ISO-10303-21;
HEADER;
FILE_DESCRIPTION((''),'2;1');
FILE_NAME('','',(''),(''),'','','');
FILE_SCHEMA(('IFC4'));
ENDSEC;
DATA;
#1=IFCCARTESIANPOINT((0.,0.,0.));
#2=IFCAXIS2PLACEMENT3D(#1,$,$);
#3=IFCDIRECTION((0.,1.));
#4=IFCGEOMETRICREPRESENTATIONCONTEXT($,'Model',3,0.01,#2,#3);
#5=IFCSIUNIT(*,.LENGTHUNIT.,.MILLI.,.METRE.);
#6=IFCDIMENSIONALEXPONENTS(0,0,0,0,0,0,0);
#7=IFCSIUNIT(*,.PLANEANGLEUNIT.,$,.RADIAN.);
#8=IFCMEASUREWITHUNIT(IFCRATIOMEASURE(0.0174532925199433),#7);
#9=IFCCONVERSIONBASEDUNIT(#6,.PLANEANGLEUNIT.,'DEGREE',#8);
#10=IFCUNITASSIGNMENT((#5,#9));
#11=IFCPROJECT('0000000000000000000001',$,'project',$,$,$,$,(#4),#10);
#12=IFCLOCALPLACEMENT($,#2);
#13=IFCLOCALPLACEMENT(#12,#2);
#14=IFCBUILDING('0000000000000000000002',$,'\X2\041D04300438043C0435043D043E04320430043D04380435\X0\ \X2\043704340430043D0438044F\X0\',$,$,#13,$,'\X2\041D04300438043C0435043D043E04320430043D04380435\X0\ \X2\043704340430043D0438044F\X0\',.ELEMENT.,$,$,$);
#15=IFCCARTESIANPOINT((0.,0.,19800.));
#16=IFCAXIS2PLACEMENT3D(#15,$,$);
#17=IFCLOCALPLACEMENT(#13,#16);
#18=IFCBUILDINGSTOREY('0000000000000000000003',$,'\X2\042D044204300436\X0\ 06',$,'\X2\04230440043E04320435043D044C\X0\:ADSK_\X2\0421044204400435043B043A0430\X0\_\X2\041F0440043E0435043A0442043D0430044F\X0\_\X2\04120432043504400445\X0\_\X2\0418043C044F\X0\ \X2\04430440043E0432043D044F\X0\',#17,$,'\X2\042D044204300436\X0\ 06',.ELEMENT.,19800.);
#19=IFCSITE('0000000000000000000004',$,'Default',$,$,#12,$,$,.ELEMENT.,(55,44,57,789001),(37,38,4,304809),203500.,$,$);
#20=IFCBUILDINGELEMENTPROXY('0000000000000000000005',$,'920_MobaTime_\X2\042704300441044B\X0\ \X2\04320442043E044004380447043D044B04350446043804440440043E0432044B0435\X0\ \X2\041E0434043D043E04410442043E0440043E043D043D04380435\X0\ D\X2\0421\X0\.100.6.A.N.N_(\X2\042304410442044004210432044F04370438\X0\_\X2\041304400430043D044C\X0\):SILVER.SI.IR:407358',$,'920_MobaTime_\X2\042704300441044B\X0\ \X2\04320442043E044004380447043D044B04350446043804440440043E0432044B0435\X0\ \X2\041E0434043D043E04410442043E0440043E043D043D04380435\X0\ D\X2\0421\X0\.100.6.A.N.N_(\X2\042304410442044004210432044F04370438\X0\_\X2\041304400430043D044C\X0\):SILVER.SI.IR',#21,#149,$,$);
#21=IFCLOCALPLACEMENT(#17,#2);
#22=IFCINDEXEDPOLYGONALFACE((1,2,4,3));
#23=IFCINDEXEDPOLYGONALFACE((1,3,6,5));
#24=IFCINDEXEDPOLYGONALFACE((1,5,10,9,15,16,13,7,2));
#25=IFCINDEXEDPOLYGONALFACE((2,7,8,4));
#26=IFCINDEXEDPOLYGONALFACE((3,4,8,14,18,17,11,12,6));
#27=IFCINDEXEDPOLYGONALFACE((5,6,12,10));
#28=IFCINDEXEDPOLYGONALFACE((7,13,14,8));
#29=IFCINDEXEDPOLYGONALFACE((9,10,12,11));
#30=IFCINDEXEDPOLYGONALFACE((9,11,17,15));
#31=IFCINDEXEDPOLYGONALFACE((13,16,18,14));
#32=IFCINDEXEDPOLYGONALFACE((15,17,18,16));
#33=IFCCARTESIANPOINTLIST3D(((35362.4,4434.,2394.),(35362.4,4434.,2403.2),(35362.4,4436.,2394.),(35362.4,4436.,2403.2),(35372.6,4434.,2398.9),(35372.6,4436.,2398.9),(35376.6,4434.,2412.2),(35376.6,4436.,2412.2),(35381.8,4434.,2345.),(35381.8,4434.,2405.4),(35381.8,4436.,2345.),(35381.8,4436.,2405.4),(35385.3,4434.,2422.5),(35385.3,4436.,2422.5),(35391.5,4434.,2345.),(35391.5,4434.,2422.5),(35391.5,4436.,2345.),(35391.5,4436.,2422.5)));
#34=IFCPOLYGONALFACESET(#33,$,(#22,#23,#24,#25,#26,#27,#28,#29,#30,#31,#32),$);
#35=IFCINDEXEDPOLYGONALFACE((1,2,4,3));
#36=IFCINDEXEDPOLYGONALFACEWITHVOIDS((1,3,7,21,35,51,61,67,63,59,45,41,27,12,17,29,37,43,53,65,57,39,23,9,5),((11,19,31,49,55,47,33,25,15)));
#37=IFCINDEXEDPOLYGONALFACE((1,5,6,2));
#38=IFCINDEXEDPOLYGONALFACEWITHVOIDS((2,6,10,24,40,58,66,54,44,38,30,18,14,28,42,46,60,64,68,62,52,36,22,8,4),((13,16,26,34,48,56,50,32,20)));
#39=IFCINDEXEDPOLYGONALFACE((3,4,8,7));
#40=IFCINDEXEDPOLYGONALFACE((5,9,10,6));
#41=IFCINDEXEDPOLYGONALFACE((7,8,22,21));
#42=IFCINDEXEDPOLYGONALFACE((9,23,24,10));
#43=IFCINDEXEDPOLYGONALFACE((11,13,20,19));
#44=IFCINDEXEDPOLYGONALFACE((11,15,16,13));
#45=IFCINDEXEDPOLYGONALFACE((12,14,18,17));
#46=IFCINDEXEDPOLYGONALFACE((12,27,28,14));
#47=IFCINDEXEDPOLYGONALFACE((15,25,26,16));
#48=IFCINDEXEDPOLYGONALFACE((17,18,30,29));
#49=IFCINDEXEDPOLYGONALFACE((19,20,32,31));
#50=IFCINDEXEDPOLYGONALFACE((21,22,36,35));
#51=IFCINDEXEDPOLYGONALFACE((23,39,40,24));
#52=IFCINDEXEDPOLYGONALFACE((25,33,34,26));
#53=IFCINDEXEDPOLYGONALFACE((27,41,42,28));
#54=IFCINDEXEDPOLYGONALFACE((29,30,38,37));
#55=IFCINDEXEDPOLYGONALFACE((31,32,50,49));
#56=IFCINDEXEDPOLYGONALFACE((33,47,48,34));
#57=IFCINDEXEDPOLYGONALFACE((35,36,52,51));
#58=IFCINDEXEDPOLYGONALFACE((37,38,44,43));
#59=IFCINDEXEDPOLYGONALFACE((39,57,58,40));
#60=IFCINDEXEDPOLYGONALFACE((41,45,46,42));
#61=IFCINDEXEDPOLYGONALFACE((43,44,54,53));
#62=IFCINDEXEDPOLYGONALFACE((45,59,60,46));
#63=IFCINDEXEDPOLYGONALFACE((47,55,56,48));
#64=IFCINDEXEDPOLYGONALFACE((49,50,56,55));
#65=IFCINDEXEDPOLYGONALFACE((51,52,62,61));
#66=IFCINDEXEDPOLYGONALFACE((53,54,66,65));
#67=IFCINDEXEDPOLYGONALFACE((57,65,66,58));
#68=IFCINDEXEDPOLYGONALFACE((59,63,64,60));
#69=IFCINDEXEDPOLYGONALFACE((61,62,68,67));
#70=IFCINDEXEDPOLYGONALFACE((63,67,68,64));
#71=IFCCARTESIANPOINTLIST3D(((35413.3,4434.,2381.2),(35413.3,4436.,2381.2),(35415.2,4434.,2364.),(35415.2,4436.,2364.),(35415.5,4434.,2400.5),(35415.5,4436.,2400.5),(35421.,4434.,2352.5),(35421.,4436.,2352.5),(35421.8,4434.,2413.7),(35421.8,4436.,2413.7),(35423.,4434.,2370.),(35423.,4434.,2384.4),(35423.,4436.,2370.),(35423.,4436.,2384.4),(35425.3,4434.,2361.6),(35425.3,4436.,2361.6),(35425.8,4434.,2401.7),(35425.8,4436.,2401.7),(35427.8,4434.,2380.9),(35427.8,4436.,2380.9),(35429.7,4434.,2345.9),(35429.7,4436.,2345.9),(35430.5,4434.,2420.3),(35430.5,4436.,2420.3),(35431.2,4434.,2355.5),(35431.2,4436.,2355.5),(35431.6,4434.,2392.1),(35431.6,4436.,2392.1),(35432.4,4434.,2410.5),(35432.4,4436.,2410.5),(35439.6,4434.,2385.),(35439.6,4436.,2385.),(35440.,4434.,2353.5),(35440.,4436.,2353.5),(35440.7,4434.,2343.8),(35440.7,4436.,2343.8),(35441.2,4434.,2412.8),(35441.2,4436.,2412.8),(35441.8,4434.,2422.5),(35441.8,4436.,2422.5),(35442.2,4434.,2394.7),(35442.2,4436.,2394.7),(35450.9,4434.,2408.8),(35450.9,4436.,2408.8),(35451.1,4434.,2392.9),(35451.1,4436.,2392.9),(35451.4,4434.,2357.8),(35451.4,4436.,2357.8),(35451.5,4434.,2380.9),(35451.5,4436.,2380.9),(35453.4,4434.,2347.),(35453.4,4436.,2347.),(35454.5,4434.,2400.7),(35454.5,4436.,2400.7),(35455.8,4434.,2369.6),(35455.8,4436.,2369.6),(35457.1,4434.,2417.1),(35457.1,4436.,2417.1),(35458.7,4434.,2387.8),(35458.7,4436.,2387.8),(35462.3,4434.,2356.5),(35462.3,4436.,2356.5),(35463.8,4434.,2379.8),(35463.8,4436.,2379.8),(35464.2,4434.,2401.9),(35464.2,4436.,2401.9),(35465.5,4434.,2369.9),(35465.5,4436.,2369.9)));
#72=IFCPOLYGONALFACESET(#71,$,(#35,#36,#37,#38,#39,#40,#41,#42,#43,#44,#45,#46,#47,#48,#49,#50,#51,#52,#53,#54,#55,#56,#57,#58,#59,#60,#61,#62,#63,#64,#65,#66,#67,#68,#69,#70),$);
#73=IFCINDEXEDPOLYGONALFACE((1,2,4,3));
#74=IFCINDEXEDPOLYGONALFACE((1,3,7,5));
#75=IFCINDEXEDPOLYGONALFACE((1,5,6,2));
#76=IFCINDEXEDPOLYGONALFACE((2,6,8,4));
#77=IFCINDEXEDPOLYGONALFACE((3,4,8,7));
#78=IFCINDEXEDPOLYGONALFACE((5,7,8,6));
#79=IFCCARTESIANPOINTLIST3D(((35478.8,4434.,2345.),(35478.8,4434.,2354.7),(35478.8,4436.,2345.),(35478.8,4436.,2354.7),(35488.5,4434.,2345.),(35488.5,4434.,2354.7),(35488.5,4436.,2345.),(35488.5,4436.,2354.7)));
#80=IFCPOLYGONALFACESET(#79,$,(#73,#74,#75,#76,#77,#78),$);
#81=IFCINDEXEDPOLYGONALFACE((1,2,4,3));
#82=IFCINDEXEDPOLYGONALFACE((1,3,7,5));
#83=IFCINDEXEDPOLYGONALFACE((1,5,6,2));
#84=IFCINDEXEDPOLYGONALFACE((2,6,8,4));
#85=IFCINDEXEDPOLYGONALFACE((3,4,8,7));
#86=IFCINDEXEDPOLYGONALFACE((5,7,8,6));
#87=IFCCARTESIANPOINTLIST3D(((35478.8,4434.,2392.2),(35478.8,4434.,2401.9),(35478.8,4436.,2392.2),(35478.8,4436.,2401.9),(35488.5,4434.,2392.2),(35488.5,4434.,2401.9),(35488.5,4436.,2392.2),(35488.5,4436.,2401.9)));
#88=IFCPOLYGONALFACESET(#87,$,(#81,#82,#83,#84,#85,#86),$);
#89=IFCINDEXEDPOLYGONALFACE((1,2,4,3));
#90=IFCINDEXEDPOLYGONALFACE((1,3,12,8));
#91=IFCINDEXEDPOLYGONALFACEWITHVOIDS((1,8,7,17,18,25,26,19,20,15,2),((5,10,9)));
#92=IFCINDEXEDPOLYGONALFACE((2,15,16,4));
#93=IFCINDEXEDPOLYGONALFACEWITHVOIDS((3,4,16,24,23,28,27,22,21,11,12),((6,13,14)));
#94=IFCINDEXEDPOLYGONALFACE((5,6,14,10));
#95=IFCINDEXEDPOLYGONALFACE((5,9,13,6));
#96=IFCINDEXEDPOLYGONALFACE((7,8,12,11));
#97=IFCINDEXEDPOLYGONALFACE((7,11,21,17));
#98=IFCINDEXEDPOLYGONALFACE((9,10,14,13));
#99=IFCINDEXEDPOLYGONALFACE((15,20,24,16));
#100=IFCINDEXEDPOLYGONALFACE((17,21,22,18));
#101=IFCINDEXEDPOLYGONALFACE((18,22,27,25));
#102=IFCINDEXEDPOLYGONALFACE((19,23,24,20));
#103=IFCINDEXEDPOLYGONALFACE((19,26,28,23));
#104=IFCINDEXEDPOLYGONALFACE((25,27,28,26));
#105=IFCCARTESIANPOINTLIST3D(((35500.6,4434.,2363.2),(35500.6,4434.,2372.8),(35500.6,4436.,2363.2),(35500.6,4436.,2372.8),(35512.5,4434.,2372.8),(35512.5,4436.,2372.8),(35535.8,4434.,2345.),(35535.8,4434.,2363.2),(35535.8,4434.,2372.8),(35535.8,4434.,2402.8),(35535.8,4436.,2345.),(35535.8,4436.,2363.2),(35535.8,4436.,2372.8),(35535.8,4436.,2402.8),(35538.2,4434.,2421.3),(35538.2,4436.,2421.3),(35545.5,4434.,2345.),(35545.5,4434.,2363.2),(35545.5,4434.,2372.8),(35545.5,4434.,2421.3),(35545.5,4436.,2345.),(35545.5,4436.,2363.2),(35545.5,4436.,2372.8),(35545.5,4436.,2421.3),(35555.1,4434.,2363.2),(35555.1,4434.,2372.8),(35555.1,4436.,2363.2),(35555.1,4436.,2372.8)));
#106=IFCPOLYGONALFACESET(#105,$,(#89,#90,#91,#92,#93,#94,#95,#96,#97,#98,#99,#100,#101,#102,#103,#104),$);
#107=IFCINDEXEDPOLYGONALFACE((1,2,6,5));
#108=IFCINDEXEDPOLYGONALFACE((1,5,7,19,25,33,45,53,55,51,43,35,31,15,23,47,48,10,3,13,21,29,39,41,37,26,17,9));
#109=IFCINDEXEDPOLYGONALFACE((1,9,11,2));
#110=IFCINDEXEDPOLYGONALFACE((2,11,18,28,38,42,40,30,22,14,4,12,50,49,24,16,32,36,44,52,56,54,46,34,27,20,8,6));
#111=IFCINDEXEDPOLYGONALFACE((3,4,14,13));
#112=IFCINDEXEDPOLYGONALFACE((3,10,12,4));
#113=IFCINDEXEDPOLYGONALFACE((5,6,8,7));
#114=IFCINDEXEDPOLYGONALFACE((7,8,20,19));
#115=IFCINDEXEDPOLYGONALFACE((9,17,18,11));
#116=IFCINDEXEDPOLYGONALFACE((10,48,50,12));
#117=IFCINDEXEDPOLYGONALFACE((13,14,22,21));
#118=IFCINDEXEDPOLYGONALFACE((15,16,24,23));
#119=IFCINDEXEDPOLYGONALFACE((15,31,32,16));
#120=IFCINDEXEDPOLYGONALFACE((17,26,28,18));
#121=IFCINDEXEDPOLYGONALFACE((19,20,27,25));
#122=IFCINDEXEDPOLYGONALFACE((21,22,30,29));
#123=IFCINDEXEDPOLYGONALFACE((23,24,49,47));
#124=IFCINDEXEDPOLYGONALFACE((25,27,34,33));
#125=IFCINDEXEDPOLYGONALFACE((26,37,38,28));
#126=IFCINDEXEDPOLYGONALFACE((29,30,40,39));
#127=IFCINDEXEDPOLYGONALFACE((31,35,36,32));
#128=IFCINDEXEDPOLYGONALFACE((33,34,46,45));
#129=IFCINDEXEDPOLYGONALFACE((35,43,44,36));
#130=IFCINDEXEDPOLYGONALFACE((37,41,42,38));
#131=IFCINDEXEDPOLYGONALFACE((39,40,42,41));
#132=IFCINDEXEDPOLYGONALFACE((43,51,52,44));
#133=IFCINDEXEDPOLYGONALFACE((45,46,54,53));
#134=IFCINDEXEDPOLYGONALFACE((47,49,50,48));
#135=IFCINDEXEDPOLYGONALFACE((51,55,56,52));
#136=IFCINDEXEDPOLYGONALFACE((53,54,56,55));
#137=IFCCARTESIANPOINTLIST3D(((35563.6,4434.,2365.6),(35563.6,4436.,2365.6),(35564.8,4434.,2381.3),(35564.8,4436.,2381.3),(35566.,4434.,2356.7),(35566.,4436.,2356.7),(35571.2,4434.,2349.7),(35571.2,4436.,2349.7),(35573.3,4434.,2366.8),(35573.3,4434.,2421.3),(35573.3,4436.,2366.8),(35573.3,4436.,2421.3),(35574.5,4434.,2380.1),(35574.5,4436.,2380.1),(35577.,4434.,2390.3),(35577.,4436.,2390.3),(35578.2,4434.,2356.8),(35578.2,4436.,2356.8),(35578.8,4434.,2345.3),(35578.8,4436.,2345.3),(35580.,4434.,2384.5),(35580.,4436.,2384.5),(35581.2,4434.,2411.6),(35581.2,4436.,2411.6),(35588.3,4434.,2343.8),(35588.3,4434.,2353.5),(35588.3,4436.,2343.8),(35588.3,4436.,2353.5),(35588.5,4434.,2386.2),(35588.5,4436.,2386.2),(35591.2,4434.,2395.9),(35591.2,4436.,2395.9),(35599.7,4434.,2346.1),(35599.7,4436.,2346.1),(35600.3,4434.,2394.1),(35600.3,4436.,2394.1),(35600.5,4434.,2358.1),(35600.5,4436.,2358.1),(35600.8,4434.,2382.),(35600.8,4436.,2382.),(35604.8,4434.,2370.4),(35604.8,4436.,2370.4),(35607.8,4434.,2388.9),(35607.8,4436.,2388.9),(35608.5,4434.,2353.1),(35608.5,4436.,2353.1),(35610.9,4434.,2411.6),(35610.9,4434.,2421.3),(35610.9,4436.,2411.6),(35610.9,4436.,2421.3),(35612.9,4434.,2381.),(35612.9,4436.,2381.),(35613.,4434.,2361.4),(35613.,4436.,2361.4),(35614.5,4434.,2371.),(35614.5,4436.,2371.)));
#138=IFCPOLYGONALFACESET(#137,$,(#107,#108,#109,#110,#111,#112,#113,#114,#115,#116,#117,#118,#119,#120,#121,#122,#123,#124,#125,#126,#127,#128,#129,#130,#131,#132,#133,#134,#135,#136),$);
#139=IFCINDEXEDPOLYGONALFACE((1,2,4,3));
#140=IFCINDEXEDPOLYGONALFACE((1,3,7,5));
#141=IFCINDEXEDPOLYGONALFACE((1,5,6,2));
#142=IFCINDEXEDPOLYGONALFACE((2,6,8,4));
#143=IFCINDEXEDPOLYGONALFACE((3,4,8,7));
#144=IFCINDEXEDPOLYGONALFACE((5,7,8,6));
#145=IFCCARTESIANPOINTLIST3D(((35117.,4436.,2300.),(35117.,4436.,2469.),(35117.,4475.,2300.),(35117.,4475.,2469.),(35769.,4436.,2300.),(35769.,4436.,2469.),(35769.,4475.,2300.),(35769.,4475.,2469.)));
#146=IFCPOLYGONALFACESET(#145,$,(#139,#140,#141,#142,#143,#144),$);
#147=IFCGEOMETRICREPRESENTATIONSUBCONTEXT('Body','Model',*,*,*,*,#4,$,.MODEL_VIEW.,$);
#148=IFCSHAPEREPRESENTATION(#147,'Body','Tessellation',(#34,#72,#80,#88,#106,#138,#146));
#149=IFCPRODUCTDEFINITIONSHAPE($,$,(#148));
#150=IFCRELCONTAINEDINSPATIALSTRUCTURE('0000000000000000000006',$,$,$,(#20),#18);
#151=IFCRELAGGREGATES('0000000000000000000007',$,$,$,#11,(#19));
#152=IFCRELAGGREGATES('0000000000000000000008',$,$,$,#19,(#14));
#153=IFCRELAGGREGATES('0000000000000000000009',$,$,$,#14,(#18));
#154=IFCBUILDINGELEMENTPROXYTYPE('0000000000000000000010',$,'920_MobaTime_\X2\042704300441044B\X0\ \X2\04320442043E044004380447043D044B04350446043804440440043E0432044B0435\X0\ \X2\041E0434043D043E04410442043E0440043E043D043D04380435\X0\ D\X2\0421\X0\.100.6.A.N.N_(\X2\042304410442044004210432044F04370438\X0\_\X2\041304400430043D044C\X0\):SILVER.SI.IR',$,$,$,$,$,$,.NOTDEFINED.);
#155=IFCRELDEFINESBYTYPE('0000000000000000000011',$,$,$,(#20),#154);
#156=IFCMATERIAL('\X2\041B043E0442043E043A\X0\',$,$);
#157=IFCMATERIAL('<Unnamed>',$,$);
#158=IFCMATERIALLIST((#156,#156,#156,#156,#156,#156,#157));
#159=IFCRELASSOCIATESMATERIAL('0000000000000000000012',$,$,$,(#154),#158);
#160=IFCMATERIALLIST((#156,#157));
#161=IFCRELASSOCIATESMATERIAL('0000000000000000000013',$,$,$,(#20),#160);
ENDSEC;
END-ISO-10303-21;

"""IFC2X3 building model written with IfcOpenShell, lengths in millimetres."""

from ifc_helpers import new_model, entity, si_unit, converted_unit, direction, frame, origin, origin_2d_with_axis, place, context, subcontext, project, spatial, polyline, rectangle, outline, extrude, source, transform, mapped, material, material_list, type_object, type_shapes, element, save


model = new_model("IFC2X3")

# Units and contexts
model_context = context("Model", 3, precision=0.01, world=origin(), true_north=direction((0.0, 1.0)))
body_context = subcontext(model_context, "Body", "Model", "MODEL_VIEW")
ifc_project = project(units=[si_unit("LENGTHUNIT", "METRE", prefix="MILLI"), converted_unit("PLANEANGLEUNIT", "DEGREE", entity("IfcRatioMeasure", 0.0174532925199433), si_unit("PLANEANGLEUNIT", "RADIAN"), dimensions=[0, 0, 0, 0, 0, 0, 0])], contexts=[model_context])

# Site, building, storey
site_placement = place(None, frame((0.0, 0.0, 0.0)))
site = spatial("IfcSite", under=ifc_project, at=site_placement, Name="Default", CompositionType="ELEMENT", RefLatitude=(55, 44, 57, 789001), RefLongitude=(37, 38, 4, 304809), RefElevation=203500.0)
building_placement = place(site_placement, origin())
building = spatial("IfcBuilding", under=site, at=building_placement, Name="Наименование здания", LongName="Наименование здания", CompositionType="ELEMENT")
storey_placement = place(building_placement, frame((0.0, 0.0, 19800.0)))
storey = spatial("IfcBuildingStorey", under=building, at=storey_placement, Name="Этаж 06", ObjectType="Уровень:ADSK_Стрелка_Проектная_Вверх_Имя уровня", LongName="Этаж 06", CompositionType="ELEMENT", Elevation=19800.0)

# Building element proxy
ifc_material_1 = material(Name="Лоток")
ifc_material_2 = material(Name="<Unnamed>")
ifc_material_list_1 = material_list([ifc_material_1, ifc_material_1, ifc_material_1, ifc_material_1, ifc_material_1, ifc_material_1, ifc_material_2])
building_element_proxy_type_1 = type_object("IfcBuildingElementProxyType", Name="920_MobaTime_Часы вторичныецифровые Односторонние DС.100.6.A.N.N_(УстрСвязи_Грань):SILVER.SI.IR", PredefinedType="NOTDEFINED", material=ifc_material_list_1)
shared_shape_1 = source(origin(), body_context, "Body", "SweptSolid", [
    extrude(outline(polyline([(-49.3, -13.1), (28.2, -13.1), (28.2, -6.8), (17.9, 1.8), (8.9, 16.0), (-0.3, 16.0), (4.6, 5.8), (11.1, -3.4), (-49.3, -3.4), (-49.3, -13.1)])), frame((-64.6, 9.8, 39.0), z_axis=(0.0, 0.0, 1.0), x_axis=(0.0, 1.0, 0.0)), (0.0, 0.0, 1.0), 2.0),
    extrude(outline(polyline([(2.2, -27.6), (19.0, -27.6), (30.5, -16.1), (33.3, -4.9), (31.0, 5.8), (21.8, 17.2), (5.2, 27.3), (-11.1, 33.0), (-24.0, 32.7), (-33.6, 27.6), (-40.3, 18.6), (-42.8, 5.7), (-38.0, -6.3), (-27.2, -15.0), (-17.5, -17.7), (-8.2, -16.4), (-0.3, -11.9), (5.1, -4.5), (7.3, 6.2), (4.0, 17.2), (18.5, 7.3), (23.6, -2.4), (22.0, -11.4), (14.2, -18.4), (5.3, -18.3), (2.2, -27.6)]), holes=[polyline([(-9.0, 23.3), (-1.3, 14.4), (-2.6, 2.0), (-11.4, -7.0), (-23.4, -6.1), (-32.2, 2.9), (-31.2, 15.1), (-25.6, 22.1), (-17.5, 24.9), (-9.0, 23.3)])]), frame((-2.7, 3.6, 39.0), z_axis=(0.0, 0.0, 1.0), x_axis=(-0.427649, 0.903945, 0.0)), (0.0, 0.0, 1.0), 2.0),
    extrude(rectangle(XDim=9.7, YDim=9.7, at=origin_2d_with_axis()), frame((40.6, -34.7, 39.0)), (0.0, 0.0, 1.0), 2.0),
    extrude(rectangle(XDim=9.7, YDim=9.7, at=origin_2d_with_axis()), frame((40.6, 12.6, 39.0)), (0.0, 0.0, 1.0), 2.0),
    extrude(outline(polyline([(-0.9, -28.1), (8.8, -28.1), (8.8, -9.9), (18.5, -9.9), (18.5, -0.2), (8.8, -0.2), (8.8, 48.3), (1.5, 48.3), (-36.0, -0.2), (-36.0, -9.9), (-0.9, -9.9), (-0.9, -28.1)]), holes=[polyline([(-0.9, -0.2), (-24.1, -0.2), (-0.9, 29.7), (-0.9, -0.2)])]), frame((93.6, -11.4, 39.0)), (0.0, 0.0, 1.0), 2.0),
    extrude(outline(polyline([(3.3, -28.3), (12.5, -28.3), (20.5, -25.0), (26.8, -18.8), (30.7, -10.0), (31.4, 1.6), (26.9, 11.8), (20.1, 18.4), (11.1, 22.3), (1.0, 23.3), (-7.9, 20.4), (-14.9, 14.5), (-18.9, 6.2), (-17.1, -9.0), (-36.7, 0.5), (-29.1, 29.3), (-38.5, 31.7), (-48.1, -4.6), (-11.6, -23.0), (-8.0, -14.0), (-10.8, -7.6), (-10.2, 1.1), (-3.0, 11.8), (9.2, 12.8), (20.0, 5.4), (21.3, -7.5), (15.5, -16.4), (4.6, -18.6), (3.3, -28.3)])), frame((147.1, -8.5, 39.0), z_axis=(0.0, 0.0, 1.0), x_axis=(0.256974, -0.966418, 0.0)), (0.0, 0.0, 1.0), 2.0),
    extrude(rectangle(XDim=652.0, YDim=169.0, at=origin_2d_with_axis()), frame((0.0, 0.0, 0.0), z_axis=(0.0, 0.0, 1.0), x_axis=(-1.0, 0.0, 0.0)), (0.0, 0.0, 1.0), 39.0),
])
type_shapes(building_element_proxy_type_1, [shared_shape_1])
ifc_material_list_2 = material_list([ifc_material_1, ifc_material_2])
proxy_1_placement = place(storey_placement, frame((35443.0, 4475.0, 2384.5), z_axis=(0.0, -1.0, 0.0), x_axis=(1.0, 0.0, 0.0)))
element("IfcBuildingElementProxy", 1, at=proxy_1_placement, inside=storey, type_object=building_element_proxy_type_1, material=ifc_material_list_2, Name="920_MobaTime_Часы вторичныецифровые Односторонние DС.100.6.A.N.N_(УстрСвязи_Грань):SILVER.SI.IR:407358", ObjectType="920_MobaTime_Часы вторичныецифровые Односторонние DС.100.6.A.N.N_(УстрСвязи_Грань):SILVER.SI.IR", context=body_context, shape_type="MappedRepresentation", body=[
    mapped(shared_shape_1, transform((0.0, 0.0, 0.0), scale=1.0)),
])

save(model, "model.ifc")
